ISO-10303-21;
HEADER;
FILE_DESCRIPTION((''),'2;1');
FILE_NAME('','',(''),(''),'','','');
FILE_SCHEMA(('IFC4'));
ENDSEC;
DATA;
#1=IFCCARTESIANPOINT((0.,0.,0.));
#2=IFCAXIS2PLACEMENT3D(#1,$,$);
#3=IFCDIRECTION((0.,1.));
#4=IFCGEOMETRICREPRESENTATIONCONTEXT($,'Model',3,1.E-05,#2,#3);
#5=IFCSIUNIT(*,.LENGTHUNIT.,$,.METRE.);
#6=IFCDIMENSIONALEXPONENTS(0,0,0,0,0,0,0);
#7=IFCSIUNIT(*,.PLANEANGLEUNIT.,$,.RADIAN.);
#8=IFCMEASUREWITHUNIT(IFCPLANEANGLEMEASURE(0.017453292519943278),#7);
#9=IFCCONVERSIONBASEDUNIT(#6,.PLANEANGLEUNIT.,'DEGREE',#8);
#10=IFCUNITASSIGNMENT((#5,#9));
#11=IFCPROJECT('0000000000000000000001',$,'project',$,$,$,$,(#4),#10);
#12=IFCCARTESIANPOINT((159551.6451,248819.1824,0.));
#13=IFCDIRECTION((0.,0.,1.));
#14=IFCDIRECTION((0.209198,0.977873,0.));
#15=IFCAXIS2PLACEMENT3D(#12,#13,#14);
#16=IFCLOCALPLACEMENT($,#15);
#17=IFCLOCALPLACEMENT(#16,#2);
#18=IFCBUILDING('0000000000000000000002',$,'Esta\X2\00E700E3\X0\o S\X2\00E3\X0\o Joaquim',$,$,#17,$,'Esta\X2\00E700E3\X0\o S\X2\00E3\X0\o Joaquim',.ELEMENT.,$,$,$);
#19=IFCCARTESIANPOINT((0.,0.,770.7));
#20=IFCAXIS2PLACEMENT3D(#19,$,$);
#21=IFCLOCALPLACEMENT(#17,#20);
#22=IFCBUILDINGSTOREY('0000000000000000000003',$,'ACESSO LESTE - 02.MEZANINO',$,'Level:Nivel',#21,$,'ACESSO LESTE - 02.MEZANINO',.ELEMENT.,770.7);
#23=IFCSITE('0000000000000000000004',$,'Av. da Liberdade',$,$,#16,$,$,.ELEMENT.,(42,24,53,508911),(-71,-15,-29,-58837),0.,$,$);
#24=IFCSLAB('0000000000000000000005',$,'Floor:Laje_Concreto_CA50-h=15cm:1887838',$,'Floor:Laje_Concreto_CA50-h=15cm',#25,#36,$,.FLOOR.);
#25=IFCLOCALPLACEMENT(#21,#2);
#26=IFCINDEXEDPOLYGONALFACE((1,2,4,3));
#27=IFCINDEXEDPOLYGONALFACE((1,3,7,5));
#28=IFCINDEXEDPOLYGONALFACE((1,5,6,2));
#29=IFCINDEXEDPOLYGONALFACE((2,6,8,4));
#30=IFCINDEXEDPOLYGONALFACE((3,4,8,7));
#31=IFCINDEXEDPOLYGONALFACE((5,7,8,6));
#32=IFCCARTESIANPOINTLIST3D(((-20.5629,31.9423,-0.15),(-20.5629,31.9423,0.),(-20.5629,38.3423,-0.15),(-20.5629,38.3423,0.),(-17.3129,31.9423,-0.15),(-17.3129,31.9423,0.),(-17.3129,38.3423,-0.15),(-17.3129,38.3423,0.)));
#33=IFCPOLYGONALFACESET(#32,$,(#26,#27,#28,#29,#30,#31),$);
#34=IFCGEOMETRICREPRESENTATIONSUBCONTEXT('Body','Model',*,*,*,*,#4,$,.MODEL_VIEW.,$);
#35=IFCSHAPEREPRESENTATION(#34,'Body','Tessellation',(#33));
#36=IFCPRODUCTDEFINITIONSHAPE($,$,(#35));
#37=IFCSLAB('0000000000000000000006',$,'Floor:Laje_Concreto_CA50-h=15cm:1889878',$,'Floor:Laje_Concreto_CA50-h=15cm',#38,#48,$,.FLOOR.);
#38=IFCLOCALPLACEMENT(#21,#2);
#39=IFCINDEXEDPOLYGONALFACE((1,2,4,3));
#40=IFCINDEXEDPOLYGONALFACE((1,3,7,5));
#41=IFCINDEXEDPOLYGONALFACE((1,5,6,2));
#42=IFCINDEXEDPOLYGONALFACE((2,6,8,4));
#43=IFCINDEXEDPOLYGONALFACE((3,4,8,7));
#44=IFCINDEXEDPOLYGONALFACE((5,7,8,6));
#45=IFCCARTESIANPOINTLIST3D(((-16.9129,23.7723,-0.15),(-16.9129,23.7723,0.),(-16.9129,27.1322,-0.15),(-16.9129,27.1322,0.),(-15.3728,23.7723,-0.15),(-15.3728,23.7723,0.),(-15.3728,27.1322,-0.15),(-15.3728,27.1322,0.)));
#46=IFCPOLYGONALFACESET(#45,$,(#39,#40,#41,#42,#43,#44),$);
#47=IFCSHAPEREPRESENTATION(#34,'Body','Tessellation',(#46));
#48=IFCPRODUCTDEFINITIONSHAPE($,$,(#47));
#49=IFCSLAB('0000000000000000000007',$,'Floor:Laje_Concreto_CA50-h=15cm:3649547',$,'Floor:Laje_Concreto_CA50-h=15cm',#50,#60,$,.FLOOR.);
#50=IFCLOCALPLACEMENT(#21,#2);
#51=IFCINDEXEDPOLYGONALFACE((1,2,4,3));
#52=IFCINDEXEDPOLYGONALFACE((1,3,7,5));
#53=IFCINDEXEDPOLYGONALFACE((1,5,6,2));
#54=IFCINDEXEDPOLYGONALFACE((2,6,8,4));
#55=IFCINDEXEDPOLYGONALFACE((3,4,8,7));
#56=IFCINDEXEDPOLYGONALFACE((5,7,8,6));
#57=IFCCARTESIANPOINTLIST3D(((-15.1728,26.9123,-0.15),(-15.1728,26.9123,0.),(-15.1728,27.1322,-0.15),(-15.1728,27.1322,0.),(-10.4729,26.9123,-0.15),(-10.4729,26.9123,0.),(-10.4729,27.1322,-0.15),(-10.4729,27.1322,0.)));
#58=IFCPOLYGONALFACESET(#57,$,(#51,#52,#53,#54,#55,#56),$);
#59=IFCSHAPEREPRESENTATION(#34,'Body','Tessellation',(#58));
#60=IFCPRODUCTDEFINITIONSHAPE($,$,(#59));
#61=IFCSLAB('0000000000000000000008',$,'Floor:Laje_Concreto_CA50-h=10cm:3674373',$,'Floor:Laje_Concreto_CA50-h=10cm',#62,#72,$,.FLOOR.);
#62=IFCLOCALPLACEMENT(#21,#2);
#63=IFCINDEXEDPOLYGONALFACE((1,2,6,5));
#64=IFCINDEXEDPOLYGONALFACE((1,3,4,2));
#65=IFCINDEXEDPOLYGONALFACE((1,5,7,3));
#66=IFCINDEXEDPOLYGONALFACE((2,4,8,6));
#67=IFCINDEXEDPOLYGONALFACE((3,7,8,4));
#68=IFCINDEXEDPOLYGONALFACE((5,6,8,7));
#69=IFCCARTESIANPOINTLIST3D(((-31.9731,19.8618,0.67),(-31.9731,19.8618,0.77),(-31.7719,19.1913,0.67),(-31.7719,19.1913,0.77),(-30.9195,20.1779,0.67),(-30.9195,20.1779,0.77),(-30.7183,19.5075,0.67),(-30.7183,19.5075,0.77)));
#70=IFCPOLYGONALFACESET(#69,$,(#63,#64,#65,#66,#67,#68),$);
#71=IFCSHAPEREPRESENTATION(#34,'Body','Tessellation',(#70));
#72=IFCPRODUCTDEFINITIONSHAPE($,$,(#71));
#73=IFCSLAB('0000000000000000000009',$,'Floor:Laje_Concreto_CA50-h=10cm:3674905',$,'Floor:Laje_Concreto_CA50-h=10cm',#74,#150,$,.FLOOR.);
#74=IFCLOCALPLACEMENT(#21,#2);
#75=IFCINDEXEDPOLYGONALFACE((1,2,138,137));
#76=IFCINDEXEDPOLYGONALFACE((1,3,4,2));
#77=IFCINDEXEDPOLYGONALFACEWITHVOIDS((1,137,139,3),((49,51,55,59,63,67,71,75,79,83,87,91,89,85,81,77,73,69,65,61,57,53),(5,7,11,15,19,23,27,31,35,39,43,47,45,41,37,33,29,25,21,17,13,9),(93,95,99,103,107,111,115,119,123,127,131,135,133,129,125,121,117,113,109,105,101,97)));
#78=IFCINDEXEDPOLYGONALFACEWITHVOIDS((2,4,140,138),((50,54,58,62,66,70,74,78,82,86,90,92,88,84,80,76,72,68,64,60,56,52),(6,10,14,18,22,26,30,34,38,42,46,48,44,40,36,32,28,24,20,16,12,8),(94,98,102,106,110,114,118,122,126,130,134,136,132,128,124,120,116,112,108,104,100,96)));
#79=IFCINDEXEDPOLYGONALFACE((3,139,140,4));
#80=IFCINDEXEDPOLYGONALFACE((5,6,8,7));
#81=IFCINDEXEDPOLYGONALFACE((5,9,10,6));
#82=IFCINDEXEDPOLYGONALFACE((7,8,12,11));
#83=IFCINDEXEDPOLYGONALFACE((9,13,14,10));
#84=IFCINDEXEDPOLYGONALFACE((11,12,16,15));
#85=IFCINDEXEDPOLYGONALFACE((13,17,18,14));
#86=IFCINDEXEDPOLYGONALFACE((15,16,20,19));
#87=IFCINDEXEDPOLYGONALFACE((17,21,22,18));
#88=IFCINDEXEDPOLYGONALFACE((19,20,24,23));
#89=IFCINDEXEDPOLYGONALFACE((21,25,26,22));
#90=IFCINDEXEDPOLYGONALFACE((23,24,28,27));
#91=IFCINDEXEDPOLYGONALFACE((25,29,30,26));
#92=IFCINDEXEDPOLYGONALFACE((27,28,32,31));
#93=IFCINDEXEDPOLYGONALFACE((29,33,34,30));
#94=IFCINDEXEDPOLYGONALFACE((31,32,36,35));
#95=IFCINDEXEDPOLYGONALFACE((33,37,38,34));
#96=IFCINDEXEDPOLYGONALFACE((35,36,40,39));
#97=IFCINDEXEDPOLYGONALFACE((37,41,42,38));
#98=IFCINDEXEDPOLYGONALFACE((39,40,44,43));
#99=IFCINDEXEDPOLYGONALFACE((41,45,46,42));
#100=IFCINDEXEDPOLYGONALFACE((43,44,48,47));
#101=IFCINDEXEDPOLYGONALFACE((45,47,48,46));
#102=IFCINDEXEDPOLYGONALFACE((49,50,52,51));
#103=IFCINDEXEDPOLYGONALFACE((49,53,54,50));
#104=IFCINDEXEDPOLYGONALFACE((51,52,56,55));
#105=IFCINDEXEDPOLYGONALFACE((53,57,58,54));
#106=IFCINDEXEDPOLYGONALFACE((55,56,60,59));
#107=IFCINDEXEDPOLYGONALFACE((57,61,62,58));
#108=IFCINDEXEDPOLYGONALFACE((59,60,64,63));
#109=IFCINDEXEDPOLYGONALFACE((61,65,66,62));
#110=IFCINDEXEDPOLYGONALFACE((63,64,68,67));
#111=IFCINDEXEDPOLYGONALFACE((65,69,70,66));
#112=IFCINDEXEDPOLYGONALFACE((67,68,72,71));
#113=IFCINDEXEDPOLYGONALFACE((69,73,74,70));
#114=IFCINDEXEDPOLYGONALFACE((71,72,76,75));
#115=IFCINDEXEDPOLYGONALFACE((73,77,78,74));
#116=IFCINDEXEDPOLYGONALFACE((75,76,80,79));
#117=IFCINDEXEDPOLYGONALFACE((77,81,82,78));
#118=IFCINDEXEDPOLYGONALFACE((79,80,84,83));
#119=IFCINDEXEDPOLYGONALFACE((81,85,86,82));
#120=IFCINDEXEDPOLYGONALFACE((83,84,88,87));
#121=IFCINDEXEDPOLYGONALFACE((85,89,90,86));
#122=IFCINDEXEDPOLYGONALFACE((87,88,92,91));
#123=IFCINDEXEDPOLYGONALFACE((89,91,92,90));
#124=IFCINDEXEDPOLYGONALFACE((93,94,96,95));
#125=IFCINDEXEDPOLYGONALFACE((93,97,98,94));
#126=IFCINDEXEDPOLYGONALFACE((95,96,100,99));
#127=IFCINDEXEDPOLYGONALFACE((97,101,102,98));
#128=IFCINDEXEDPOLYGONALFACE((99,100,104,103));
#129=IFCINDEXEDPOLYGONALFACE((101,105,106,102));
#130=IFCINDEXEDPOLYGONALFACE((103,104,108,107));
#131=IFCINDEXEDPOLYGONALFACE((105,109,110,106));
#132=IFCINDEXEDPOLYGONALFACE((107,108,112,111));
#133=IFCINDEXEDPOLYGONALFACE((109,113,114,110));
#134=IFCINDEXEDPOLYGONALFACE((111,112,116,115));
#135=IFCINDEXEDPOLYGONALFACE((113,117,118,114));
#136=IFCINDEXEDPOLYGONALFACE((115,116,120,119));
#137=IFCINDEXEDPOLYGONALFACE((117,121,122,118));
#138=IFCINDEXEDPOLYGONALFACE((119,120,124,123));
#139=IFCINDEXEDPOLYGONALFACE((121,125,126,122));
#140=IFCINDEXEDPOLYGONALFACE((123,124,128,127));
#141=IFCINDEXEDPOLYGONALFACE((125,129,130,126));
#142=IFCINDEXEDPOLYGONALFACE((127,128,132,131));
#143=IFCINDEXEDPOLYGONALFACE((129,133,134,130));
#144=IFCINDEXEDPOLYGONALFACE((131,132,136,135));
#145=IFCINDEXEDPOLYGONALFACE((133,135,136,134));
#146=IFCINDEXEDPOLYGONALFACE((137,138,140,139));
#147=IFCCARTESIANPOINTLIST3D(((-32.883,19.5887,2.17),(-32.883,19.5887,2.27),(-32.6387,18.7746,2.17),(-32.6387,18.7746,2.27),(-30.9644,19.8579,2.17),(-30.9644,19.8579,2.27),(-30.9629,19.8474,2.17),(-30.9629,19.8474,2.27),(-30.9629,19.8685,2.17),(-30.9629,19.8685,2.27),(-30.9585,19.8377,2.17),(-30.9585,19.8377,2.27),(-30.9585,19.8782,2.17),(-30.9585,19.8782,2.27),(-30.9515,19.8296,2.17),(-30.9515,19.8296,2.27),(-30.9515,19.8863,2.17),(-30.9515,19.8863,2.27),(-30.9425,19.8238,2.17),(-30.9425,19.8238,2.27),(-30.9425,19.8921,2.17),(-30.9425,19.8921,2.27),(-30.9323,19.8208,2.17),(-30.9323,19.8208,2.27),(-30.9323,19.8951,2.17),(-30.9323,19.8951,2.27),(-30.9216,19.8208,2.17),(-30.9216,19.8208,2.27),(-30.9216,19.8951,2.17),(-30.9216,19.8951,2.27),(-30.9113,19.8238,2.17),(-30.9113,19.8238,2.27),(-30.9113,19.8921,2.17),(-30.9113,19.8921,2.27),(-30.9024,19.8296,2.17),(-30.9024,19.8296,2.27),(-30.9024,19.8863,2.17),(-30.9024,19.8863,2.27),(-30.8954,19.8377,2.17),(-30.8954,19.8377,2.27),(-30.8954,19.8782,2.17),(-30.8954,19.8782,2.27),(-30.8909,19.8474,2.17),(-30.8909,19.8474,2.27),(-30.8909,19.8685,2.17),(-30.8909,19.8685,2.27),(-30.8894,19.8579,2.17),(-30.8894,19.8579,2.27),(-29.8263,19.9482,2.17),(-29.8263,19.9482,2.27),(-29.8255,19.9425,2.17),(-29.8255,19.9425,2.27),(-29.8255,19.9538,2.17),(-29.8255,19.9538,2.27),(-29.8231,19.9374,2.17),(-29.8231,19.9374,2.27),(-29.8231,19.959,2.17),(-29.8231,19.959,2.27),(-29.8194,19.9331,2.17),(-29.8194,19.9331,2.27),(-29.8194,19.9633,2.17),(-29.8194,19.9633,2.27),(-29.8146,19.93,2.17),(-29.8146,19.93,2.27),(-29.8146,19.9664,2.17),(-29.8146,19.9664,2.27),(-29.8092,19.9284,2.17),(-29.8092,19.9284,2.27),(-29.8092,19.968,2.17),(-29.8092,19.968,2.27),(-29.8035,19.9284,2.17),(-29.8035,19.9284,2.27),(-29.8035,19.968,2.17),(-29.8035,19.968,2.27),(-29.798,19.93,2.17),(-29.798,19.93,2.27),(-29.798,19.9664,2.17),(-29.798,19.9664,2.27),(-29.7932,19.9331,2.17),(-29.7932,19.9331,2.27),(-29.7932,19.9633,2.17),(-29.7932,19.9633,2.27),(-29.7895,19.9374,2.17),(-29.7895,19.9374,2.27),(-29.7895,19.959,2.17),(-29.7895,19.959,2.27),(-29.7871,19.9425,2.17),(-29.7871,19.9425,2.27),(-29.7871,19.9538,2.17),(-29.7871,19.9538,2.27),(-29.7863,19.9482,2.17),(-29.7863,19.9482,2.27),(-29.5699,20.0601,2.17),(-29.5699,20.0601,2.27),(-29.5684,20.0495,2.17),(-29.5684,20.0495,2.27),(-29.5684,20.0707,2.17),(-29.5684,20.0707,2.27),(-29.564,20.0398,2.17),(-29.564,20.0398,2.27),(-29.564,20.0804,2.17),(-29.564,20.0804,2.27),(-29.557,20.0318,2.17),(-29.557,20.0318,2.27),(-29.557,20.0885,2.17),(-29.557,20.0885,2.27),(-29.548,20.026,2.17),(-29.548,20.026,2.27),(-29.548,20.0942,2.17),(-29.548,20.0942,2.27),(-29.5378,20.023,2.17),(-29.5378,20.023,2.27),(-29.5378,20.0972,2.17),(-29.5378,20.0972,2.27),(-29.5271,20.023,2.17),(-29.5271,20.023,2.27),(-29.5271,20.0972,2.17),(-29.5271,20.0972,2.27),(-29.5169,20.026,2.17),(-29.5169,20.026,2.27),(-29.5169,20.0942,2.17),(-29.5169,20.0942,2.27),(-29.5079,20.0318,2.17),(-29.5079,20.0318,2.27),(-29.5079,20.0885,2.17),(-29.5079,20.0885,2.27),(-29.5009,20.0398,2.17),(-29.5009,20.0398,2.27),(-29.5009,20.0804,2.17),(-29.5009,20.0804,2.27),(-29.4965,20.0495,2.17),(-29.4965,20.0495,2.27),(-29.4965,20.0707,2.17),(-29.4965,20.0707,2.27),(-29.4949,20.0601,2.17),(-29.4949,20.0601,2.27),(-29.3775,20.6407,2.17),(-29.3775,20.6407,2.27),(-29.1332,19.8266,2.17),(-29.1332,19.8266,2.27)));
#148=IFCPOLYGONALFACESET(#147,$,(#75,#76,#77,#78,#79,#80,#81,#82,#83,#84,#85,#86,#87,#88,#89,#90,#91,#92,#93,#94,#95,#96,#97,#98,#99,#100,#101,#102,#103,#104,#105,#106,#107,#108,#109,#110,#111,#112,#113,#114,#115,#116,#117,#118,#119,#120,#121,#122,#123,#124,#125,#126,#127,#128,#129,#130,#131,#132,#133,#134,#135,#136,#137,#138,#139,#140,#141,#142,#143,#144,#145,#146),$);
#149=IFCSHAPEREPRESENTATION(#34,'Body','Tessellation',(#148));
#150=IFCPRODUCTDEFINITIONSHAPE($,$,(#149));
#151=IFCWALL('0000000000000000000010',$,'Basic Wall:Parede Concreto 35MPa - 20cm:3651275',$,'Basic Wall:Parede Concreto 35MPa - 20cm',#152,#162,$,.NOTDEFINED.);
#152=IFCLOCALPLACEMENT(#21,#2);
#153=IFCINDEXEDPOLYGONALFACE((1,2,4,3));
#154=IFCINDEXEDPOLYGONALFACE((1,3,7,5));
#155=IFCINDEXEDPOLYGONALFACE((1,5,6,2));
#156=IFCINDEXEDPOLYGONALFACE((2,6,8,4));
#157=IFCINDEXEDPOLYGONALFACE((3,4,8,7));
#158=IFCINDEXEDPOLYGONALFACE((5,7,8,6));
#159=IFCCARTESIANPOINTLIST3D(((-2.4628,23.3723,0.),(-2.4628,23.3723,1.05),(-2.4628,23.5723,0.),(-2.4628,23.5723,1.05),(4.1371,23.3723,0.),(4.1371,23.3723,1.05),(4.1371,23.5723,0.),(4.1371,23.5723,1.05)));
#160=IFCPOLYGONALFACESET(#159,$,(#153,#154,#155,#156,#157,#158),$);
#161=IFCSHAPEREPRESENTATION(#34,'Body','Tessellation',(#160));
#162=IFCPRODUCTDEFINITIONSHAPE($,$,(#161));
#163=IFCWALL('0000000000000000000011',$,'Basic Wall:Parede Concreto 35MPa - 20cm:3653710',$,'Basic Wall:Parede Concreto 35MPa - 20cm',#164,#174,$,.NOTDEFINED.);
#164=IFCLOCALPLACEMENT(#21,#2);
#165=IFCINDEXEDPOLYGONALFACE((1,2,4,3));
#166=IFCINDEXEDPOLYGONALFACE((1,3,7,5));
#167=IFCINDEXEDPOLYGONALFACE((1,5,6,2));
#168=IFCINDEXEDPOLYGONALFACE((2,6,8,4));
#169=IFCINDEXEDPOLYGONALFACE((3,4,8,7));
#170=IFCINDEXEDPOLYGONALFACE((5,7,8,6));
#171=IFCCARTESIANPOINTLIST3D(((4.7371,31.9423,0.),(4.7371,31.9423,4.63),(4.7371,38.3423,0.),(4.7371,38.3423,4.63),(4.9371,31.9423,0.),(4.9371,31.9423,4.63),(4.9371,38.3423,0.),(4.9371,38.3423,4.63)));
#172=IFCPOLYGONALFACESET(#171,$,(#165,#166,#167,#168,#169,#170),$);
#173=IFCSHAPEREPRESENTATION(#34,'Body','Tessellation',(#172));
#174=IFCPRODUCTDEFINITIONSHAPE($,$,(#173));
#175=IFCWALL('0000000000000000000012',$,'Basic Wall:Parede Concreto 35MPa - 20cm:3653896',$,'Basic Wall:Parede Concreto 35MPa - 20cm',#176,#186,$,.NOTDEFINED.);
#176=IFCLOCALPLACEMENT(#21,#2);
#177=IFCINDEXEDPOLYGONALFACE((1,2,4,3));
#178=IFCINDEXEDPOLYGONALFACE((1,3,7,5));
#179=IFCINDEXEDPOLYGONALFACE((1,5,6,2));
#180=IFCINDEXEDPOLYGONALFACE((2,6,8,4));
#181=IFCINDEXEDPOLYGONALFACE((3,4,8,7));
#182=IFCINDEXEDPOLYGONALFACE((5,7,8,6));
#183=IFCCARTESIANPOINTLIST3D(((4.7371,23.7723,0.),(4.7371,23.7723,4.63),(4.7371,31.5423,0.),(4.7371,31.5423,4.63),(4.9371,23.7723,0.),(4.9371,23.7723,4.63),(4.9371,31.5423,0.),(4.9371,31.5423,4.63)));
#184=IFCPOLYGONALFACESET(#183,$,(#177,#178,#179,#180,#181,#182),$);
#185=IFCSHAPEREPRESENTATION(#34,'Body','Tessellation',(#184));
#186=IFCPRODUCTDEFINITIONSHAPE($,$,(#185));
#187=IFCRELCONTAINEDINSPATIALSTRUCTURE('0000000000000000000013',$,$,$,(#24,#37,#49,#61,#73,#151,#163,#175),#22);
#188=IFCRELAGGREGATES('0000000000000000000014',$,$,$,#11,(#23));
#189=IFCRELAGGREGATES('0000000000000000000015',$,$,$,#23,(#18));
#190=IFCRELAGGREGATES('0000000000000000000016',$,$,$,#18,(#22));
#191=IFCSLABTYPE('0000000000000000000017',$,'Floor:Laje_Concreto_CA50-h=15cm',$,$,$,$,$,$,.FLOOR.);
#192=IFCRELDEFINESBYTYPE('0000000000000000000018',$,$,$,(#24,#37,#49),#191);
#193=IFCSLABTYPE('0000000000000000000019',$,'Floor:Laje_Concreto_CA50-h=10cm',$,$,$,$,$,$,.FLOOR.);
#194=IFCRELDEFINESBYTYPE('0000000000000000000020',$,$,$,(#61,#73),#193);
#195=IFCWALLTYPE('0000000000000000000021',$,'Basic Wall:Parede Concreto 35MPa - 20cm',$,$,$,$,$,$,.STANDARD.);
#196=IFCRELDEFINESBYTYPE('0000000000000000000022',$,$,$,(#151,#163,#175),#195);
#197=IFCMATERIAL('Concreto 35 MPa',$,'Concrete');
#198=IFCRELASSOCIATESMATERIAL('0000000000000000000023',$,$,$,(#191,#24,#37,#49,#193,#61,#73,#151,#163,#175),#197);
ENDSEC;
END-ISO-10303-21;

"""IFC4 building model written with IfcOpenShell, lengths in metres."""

from ifc_helpers import new_model, entity, si_unit, converted_unit, direction, frame, origin, place, context, subcontext, project, spatial, arc, indexed_curve, outline, extrude, material, type_object, element, save


model = new_model("IFC4")

# Units and contexts
model_context = context("Model", 3, precision=1e-05, world=origin(), true_north=direction((0.0, 1.0)))
body_context = subcontext(model_context, "Body", "Model", "MODEL_VIEW")
ifc_project = project(units=[si_unit("LENGTHUNIT", "METRE"), converted_unit("PLANEANGLEUNIT", "DEGREE", entity("IfcPlaneAngleMeasure", 0.017453292519943278), si_unit("PLANEANGLEUNIT", "RADIAN"), dimensions=[0, 0, 0, 0, 0, 0, 0])], contexts=[model_context])

# Site, building, storey
site_placement = place(None, frame((159551.6451, 248819.1824, 0.0), z_axis=(0.0, 0.0, 1.0), x_axis=(0.209198, 0.977873, 0.0)))
site = spatial("IfcSite", under=ifc_project, at=site_placement, Name="Av. da Liberdade", CompositionType="ELEMENT", RefLatitude=(42, 24, 53, 508911), RefLongitude=(-71, -15, -29, -58837), RefElevation=0.0)
building_placement = place(site_placement, origin())
building = spatial("IfcBuilding", under=site, at=building_placement, Name="Estação São Joaquim", LongName="Estação São Joaquim", CompositionType="ELEMENT")
storey_placement = place(building_placement, frame((0.0, 0.0, 770.7)))
storey = spatial("IfcBuildingStorey", under=building, at=storey_placement, Name="ACESSO LESTE - 02.MEZANINO", ObjectType="Level:Nivel", LongName="ACESSO LESTE - 02.MEZANINO", CompositionType="ELEMENT", Elevation=770.7)

# Slabs
ifc_material = material(Name="Concreto 35 MPa", Category="Concrete")
slab_type_1 = type_object("IfcSlabType", Name="Floor:Laje_Concreto_CA50-h=15cm", PredefinedType="FLOOR", material=ifc_material)
slab_1_placement = place(storey_placement, origin())
element("IfcSlab", 1, at=slab_1_placement, inside=storey, type_object=slab_type_1, material=ifc_material, Name="Floor:Laje_Concreto_CA50-h=15cm:1887838", ObjectType="Floor:Laje_Concreto_CA50-h=15cm", PredefinedType="FLOOR", context=body_context, shape_type="SweptSolid", body=[
    extrude(outline(indexed_curve([(-1.625, -3.2), (1.625, -3.2), (1.625, 3.2), (-1.625, 3.2), (-1.625, -3.2)], self_intersect=False)), frame((-18.9379, 35.1423, 0.0), z_axis=(0.0, 0.0, -1.0), x_axis=(1.0, 0.0, 0.0)), (0.0, 0.0, 1.0), 0.15),
])
slab_2_placement = place(storey_placement, origin())
element("IfcSlab", 2, at=slab_2_placement, inside=storey, type_object=slab_type_1, material=ifc_material, Name="Floor:Laje_Concreto_CA50-h=15cm:1889878", ObjectType="Floor:Laje_Concreto_CA50-h=15cm", PredefinedType="FLOOR", context=body_context, shape_type="SweptSolid", body=[
    extrude(outline(indexed_curve([(-1.6799, -0.77), (1.6799, -0.77), (1.6799, 0.77), (-1.6799, 0.77), (-1.6799, -0.77)], self_intersect=False)), frame((-16.1428, 25.4522, 0.0), z_axis=(0.0, 0.0, -1.0), x_axis=(0.0, -1.0, 0.0)), (0.0, 0.0, 1.0), 0.15),
])
slab_3_placement = place(storey_placement, origin())
element("IfcSlab", 3, at=slab_3_placement, inside=storey, type_object=slab_type_1, material=ifc_material, Name="Floor:Laje_Concreto_CA50-h=15cm:3649547", ObjectType="Floor:Laje_Concreto_CA50-h=15cm", PredefinedType="FLOOR", context=body_context, shape_type="SweptSolid", body=[
    extrude(outline(indexed_curve([(-0.1099, -2.35), (0.1099, -2.35), (0.1099, 2.35), (-0.1099, 2.35), (-0.1099, -2.35)], self_intersect=False)), frame((-12.8228, 27.0222, 0.0), z_axis=(0.0, 0.0, -1.0), x_axis=(0.0, -1.0, 0.0)), (0.0, 0.0, 1.0), 0.15),
])

# Slabs
slab_type_2 = type_object("IfcSlabType", Name="Floor:Laje_Concreto_CA50-h=10cm", PredefinedType="FLOOR", material=ifc_material)
slab_4_placement = place(storey_placement, origin())
element("IfcSlab", 4, at=slab_4_placement, inside=storey, type_object=slab_type_2, material=ifc_material, Name="Floor:Laje_Concreto_CA50-h=10cm:3674373", ObjectType="Floor:Laje_Concreto_CA50-h=10cm", PredefinedType="FLOOR", context=body_context, shape_type="SweptSolid", body=[
    extrude(outline(indexed_curve([(-0.55, -0.35), (0.55, -0.35), (0.55, 0.35), (-0.55, 0.35), (-0.55, -0.35)], self_intersect=False)), frame((-31.3457, 19.6846, 0.77), z_axis=(0.0, 0.0, -1.0), x_axis=(0.957798, 0.287441, 0.0)), (0.0, 0.0, 1.0), 0.1),
])
slab_5_placement = place(storey_placement, origin())
element("IfcSlab", 5, at=slab_5_placement, inside=storey, type_object=slab_type_2, material=ifc_material, Name="Floor:Laje_Concreto_CA50-h=10cm:3674905", ObjectType="Floor:Laje_Concreto_CA50-h=10cm", PredefinedType="FLOOR", context=body_context, shape_type="SweptSolid", body=[
    extrude(outline(indexed_curve([(-1.83, -0.425), (1.83, -0.425), (1.83, 0.425), (-1.83, 0.425), (-1.83, -0.425)], self_intersect=False), holes=[indexed_curve([(-1.4788, 0.0758), (-1.5255, 0.0507), (-1.5506, 0.0974), (-1.5039, 0.1225)], segments=[arc(1, 2, 3), arc(3, 4, 1)], self_intersect=False), indexed_curve([(-1.201, 0.1093), (-1.226, 0.0959), (-1.2394, 0.1208), (-1.2145, 0.1342)], segments=[arc(1, 2, 3), arc(3, 4, 1)], self_intersect=False), indexed_curve([(-0.085, -0.1314), (-0.1317, -0.1565), (-0.1569, -0.1098), (-0.1102, -0.0847)], segments=[arc(1, 2, 3), arc(3, 4, 1)], self_intersect=False)]), frame((-31.0081, 19.7076, 2.17), z_axis=(0.0, 0.0, 1.0), x_axis=(-0.957798, -0.287441, 0.0)), (0.0, 0.0, 1.0), 0.1),
])

# Walls
wall_type = type_object("IfcWallType", Name="Basic Wall:Parede Concreto 35MPa - 20cm", PredefinedType="STANDARD")
wall_1_placement = place(storey_placement, frame((4.1371, 23.4723, 0.0), z_axis=(0.0, 0.0, 1.0), x_axis=(-1.0, 0.0, 0.0)))
element("IfcWall", 6, at=wall_1_placement, inside=storey, type_object=wall_type, material=ifc_material, Name="Basic Wall:Parede Concreto 35MPa - 20cm:3651275", ObjectType="Basic Wall:Parede Concreto 35MPa - 20cm", PredefinedType="NOTDEFINED", context=body_context, shape_type="SweptSolid", body=[
    extrude(outline(indexed_curve([(6.5999, 0.1), (0.0, 0.1), (0.0, -0.1), (6.5999, -0.1), (6.5999, 0.1)], self_intersect=False)), origin(), (0.0, 0.0, 1.0), 1.05),
])
wall_2_placement = place(storey_placement, frame((4.8371, 38.3423, 0.0), z_axis=(0.0, 0.0, 1.0), x_axis=(0.0, -1.0, 0.0)))
element("IfcWall", 7, at=wall_2_placement, inside=storey, type_object=wall_type, material=ifc_material, Name="Basic Wall:Parede Concreto 35MPa - 20cm:3653710", ObjectType="Basic Wall:Parede Concreto 35MPa - 20cm", PredefinedType="NOTDEFINED", context=body_context, shape_type="SweptSolid", body=[
    extrude(outline(indexed_curve([(6.4, 0.1), (0.0, 0.1), (0.0, -0.1), (6.4, -0.1), (6.4, 0.1)], self_intersect=False)), origin(), (0.0, 0.0, 1.0), 4.63),
])
wall_3_placement = place(storey_placement, frame((4.8371, 31.5423, 0.0), z_axis=(0.0, 0.0, 1.0), x_axis=(0.0, -1.0, 0.0)))
element("IfcWall", 8, at=wall_3_placement, inside=storey, type_object=wall_type, material=ifc_material, Name="Basic Wall:Parede Concreto 35MPa - 20cm:3653896", ObjectType="Basic Wall:Parede Concreto 35MPa - 20cm", PredefinedType="NOTDEFINED", context=body_context, shape_type="SweptSolid", body=[
    extrude(outline(indexed_curve([(7.77, 0.1), (0.0, 0.1), (0.0, -0.1), (7.77, -0.1), (7.77, 0.1)], self_intersect=False)), origin(), (0.0, 0.0, 1.0), 4.63),
])

save(model, "model.ifc")
